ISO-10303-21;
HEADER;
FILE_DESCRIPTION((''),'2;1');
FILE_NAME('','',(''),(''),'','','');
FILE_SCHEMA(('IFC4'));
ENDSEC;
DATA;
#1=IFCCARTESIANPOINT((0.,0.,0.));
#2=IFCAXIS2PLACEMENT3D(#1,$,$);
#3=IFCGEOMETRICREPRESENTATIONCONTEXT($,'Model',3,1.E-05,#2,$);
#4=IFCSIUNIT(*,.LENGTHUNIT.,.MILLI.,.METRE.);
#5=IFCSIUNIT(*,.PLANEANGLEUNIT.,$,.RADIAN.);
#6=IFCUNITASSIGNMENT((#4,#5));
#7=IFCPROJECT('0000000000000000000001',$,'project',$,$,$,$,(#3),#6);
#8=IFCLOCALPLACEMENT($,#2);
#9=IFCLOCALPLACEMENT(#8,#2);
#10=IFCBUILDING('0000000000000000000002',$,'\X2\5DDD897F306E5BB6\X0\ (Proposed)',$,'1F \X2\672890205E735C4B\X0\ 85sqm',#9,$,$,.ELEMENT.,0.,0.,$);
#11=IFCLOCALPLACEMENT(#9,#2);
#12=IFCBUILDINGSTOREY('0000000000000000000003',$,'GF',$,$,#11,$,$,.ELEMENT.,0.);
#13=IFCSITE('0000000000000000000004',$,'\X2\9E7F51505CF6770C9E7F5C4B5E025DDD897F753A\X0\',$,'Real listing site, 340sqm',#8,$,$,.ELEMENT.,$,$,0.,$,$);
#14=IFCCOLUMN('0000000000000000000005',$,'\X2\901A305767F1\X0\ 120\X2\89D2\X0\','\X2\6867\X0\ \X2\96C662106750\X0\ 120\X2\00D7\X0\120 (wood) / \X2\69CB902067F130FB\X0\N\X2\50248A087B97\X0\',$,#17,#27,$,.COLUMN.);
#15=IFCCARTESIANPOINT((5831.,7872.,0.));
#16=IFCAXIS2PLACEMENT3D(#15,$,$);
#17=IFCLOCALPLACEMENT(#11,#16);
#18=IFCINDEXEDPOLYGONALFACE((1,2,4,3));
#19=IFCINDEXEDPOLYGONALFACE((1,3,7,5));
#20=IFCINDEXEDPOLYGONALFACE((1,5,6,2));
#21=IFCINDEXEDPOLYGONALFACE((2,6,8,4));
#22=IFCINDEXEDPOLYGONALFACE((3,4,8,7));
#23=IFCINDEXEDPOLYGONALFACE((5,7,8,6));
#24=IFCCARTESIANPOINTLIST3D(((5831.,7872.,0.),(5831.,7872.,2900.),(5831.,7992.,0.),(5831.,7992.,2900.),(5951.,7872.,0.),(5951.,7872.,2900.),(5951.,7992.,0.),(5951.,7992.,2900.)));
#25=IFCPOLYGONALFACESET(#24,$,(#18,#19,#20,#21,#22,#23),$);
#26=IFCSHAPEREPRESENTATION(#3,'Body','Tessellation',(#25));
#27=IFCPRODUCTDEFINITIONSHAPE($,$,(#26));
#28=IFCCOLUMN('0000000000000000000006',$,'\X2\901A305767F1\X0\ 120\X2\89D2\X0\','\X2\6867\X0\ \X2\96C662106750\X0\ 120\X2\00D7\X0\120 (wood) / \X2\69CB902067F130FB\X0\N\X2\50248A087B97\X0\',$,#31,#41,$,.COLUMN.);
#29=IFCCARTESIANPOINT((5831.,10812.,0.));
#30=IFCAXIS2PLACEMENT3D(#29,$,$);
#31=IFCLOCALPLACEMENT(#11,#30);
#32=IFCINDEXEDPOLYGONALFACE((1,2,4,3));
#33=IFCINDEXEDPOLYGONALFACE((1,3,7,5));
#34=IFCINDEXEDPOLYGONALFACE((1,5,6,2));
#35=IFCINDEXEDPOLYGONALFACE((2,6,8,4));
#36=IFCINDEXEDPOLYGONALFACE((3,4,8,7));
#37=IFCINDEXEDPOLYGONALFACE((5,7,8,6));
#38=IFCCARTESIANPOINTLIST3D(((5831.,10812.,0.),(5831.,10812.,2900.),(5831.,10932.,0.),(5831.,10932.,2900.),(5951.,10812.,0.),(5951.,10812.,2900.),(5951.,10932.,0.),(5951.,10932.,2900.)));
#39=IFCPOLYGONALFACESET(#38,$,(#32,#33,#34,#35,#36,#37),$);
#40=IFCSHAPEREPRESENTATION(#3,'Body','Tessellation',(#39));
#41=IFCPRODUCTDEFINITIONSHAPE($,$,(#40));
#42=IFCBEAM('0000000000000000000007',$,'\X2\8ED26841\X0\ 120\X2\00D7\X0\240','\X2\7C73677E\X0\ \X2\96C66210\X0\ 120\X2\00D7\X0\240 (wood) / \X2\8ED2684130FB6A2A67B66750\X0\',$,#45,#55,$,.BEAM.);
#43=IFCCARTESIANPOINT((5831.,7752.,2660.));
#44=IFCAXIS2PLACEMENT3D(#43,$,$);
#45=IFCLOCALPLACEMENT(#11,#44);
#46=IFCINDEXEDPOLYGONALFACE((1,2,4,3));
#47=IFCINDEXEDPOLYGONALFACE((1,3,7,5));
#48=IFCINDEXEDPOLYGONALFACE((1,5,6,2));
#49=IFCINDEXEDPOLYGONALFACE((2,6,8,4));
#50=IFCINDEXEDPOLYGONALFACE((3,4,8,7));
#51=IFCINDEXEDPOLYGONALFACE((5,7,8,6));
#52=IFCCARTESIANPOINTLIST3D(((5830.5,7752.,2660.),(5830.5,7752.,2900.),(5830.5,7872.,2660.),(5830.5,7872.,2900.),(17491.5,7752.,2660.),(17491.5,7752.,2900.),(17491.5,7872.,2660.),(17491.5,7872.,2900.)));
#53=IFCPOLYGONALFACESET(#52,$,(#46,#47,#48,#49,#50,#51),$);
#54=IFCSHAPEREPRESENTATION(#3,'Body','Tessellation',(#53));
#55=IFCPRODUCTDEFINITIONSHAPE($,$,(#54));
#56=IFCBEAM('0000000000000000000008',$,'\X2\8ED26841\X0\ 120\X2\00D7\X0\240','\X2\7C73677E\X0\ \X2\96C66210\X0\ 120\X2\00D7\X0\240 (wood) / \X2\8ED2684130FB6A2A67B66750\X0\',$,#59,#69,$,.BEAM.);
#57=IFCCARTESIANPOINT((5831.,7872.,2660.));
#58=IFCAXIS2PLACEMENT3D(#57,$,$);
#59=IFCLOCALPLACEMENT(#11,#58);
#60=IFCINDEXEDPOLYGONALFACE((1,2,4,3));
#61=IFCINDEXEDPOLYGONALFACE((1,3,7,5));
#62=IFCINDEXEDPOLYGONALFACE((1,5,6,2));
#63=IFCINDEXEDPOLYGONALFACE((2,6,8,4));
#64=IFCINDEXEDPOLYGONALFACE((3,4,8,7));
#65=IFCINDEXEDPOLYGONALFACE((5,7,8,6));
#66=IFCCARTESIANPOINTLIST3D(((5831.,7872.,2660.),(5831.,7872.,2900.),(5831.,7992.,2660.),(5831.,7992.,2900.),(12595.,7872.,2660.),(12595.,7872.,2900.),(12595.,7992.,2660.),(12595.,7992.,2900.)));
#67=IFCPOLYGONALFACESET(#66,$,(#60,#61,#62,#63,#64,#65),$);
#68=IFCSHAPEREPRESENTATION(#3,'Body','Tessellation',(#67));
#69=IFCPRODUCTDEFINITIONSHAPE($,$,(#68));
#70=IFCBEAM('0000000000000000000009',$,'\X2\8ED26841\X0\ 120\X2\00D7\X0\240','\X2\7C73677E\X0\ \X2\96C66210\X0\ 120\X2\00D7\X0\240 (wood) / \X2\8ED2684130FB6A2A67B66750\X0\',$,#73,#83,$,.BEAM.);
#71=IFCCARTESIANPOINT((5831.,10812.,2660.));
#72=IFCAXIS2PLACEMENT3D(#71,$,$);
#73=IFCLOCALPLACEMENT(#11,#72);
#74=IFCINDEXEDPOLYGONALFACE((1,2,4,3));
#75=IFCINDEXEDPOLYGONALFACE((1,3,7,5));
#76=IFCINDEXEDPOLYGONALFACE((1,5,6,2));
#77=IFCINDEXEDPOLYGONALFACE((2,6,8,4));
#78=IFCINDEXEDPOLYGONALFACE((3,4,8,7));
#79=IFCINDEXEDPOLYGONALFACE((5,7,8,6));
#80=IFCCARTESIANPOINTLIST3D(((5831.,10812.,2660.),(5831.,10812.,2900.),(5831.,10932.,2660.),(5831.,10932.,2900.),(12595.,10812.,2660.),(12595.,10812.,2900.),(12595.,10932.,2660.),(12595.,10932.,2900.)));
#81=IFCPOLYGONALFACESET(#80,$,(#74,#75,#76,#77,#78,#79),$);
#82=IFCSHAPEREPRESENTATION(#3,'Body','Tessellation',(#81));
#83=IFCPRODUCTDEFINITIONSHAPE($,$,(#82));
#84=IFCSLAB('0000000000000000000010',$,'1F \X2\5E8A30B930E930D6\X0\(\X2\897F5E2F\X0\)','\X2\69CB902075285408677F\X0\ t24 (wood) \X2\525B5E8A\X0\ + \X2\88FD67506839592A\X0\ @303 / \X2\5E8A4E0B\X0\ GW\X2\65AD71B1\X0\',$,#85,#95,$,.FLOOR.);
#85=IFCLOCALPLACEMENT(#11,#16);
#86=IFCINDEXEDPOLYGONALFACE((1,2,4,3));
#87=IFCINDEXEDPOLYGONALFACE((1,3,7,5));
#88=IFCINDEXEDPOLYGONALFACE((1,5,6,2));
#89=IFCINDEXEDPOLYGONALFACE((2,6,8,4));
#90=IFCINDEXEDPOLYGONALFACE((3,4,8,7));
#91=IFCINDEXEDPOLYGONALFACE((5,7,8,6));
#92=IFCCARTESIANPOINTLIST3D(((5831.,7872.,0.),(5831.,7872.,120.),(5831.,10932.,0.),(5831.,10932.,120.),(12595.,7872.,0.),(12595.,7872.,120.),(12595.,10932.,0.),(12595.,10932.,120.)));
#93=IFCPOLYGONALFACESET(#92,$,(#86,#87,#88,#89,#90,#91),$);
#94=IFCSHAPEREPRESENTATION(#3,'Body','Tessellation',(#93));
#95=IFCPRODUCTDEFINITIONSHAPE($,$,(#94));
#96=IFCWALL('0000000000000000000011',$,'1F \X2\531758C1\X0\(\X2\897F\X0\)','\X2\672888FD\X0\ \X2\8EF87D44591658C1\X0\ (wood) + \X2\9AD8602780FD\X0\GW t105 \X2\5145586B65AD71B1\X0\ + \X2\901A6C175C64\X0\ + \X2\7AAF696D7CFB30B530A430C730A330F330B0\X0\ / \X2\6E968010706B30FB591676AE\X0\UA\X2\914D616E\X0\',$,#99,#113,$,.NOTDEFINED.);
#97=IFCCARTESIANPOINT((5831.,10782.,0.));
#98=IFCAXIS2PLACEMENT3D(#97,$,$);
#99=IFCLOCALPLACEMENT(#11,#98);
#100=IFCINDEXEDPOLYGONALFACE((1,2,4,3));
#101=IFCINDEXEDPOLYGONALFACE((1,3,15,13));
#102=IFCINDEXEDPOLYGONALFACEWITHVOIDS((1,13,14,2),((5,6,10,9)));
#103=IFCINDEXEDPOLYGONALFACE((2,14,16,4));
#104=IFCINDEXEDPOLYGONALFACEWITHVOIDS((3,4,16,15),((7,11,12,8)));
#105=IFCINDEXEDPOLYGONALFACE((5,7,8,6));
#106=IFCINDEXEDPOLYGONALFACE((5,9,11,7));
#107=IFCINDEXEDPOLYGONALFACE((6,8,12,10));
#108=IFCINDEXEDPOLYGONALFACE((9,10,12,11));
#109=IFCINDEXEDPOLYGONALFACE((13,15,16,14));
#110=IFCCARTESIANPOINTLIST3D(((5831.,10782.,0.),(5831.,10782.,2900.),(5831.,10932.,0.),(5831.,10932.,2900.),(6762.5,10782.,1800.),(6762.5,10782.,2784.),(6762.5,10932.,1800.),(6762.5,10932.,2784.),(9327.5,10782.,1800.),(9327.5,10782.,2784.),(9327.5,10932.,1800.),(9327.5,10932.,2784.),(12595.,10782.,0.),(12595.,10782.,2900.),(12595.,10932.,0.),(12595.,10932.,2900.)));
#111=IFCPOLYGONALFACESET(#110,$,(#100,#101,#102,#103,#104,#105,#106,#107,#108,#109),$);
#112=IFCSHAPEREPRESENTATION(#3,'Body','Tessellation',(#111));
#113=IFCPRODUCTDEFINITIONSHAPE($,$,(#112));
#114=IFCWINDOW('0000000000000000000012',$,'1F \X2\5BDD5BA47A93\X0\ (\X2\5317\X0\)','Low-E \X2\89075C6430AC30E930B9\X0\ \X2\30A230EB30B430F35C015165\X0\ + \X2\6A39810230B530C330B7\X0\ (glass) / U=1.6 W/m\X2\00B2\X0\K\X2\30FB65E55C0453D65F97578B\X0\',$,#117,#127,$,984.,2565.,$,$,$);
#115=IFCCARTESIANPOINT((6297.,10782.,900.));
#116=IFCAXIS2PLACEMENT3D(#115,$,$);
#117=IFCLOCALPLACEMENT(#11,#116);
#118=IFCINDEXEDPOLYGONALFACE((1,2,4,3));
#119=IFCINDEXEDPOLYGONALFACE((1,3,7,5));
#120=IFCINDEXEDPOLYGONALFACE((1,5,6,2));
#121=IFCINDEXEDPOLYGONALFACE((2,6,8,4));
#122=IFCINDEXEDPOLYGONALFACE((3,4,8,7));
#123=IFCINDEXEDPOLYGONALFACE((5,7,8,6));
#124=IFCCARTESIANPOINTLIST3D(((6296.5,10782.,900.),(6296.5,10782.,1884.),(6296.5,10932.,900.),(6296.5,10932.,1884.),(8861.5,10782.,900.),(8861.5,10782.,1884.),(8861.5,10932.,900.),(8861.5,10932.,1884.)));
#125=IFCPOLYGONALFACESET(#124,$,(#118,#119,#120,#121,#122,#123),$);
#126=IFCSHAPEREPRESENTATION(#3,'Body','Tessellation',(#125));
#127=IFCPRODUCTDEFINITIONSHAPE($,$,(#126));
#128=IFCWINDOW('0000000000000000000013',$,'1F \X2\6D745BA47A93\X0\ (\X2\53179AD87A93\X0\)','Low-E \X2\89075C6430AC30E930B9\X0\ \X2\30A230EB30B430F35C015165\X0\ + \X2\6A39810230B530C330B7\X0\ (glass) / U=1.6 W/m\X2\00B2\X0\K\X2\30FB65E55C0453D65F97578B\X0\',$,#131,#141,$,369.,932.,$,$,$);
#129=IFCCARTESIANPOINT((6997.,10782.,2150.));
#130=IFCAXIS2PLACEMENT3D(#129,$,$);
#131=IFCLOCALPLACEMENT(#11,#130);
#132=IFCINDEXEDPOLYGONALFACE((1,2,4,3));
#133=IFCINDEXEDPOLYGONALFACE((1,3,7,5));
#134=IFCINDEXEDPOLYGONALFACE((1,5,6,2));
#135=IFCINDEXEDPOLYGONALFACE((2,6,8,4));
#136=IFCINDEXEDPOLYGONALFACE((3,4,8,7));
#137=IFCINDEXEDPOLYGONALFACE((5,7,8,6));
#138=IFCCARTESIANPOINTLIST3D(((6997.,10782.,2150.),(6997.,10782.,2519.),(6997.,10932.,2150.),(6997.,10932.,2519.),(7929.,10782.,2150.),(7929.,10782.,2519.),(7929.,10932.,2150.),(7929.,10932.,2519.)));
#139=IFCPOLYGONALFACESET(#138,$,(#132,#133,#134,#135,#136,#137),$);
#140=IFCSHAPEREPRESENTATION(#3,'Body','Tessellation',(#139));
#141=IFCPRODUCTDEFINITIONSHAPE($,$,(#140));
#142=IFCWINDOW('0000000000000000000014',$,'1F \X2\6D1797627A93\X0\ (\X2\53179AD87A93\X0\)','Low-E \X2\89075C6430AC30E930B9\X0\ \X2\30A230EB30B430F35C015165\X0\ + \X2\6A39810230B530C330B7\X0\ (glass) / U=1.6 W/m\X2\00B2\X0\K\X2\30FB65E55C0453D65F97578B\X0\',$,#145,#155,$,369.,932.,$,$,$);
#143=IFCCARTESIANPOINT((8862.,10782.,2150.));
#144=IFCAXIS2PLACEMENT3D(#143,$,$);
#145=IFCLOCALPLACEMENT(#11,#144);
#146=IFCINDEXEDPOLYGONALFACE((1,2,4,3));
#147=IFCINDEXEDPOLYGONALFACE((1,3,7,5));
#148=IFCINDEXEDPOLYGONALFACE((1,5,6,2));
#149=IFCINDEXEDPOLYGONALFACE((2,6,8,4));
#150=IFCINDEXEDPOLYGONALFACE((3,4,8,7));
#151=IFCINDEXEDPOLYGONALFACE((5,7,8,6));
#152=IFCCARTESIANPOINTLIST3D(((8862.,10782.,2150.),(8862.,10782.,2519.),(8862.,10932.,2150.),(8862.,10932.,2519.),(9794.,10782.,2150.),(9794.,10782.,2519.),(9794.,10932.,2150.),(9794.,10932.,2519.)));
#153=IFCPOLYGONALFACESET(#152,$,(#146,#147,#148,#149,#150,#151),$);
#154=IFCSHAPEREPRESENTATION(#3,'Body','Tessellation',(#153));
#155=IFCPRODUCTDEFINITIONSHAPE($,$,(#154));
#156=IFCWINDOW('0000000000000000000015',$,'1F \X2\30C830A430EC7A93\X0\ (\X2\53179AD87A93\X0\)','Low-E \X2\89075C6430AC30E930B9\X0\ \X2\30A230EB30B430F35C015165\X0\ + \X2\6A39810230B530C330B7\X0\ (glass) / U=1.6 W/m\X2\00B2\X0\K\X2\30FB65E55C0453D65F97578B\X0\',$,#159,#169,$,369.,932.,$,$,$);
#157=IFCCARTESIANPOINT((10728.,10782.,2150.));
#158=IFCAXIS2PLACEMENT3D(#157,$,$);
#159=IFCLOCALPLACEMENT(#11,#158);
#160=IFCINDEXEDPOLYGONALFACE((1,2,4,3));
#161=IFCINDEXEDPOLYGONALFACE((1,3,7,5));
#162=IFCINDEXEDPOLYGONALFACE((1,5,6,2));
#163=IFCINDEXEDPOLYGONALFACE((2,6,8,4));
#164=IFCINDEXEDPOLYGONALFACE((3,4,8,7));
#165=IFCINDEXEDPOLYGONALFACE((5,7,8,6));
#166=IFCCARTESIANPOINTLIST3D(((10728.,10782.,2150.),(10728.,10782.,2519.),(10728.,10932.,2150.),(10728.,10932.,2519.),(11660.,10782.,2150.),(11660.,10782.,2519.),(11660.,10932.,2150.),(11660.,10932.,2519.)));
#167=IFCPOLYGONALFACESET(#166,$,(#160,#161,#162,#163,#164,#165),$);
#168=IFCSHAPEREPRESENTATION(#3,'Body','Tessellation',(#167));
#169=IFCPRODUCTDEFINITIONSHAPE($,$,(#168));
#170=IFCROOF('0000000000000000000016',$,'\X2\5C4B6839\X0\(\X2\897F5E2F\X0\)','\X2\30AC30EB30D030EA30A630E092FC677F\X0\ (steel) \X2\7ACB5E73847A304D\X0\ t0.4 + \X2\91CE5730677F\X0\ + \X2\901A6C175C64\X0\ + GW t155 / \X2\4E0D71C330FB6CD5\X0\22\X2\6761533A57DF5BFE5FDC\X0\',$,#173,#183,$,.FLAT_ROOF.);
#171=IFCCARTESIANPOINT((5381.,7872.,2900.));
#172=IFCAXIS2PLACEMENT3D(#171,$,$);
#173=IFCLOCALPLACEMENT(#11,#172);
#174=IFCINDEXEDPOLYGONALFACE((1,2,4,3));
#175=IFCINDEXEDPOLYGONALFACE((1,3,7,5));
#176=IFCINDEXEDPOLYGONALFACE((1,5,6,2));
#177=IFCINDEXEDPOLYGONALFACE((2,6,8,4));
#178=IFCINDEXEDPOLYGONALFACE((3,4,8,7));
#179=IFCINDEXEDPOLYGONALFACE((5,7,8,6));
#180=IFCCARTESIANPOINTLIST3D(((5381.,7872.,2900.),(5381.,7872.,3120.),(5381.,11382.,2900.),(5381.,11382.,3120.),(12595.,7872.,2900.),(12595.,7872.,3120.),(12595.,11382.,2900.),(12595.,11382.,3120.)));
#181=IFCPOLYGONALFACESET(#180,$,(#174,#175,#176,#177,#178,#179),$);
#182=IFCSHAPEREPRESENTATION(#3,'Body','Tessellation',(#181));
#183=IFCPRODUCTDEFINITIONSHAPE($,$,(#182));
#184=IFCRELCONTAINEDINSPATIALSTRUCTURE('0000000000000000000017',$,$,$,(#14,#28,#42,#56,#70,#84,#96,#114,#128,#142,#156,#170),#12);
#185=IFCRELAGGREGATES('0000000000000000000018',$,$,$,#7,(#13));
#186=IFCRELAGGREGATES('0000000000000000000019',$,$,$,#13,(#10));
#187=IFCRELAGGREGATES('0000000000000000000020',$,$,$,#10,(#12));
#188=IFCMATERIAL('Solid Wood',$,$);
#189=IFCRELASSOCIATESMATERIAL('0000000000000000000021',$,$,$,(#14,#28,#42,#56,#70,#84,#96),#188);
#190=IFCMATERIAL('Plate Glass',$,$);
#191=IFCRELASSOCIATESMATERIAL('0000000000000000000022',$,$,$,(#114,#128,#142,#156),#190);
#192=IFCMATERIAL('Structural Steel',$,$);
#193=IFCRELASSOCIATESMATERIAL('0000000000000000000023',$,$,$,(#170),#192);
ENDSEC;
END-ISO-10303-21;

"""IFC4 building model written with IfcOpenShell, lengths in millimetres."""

from ifc_helpers import new_model, si_unit, frame, frame_2d, origin, place, context, project, spatial, rectangle, extrude, material, element, fill, save


model = new_model("IFC4")

# Units and contexts
model_context = context("Model", 3, precision=1e-05, world=origin())
ifc_project = project(units=[si_unit("LENGTHUNIT", "METRE", prefix="MILLI"), si_unit("PLANEANGLEUNIT", "RADIAN")], contexts=[model_context])

# Site, building, storey
site_placement = place(None, origin())
site = spatial("IfcSite", under=ifc_project, at=site_placement, Name="鹿児島県鹿屋市川西町", ObjectType="Real listing site, 340sqm", CompositionType="ELEMENT", RefElevation=0.0)
building_placement = place(site_placement, origin())
building = spatial("IfcBuilding", under=site, at=building_placement, Name="川西の家 (Proposed)", ObjectType="1F 木造平屋 85sqm", CompositionType="ELEMENT", ElevationOfRefHeight=0.0, ElevationOfTerrain=0.0)
storey_placement = place(building_placement, origin())
storey = spatial("IfcBuildingStorey", under=building, at=storey_placement, Name="GF", CompositionType="ELEMENT", Elevation=0.0)

# Columns
ifc_material_1 = material(Name="Solid Wood")
column_1_placement = place(storey_placement, frame((5831.0, 7872.0, 0.0)))
element("IfcColumn", 1, at=column_1_placement, inside=storey, material=ifc_material_1, Name="通し柱 120角", Description="桧 集成材 120×120 (wood) / 構造柱・N値計算", PredefinedType="COLUMN", context=model_context, shape_type="SweptSolid", body=[
    extrude(rectangle(XDim=120.0, YDim=120.0, at=frame_2d((60.0, 60.0))), frame((5831.0, 7872.0, 0.0)), (0.0, 0.0, 1.0), 2900.0),
])
column_2_placement = place(storey_placement, frame((5831.0, 10812.0, 0.0)))
element("IfcColumn", 2, at=column_2_placement, inside=storey, material=ifc_material_1, Name="通し柱 120角", Description="桧 集成材 120×120 (wood) / 構造柱・N値計算", PredefinedType="COLUMN", context=model_context, shape_type="SweptSolid", body=[
    extrude(rectangle(XDim=120.0, YDim=120.0, at=frame_2d((60.0, 60.0))), frame((5831.0, 10812.0, 0.0)), (0.0, 0.0, 1.0), 2900.0),
])

# Beams
beam_1_placement = place(storey_placement, frame((5831.0, 7752.0, 2660.0)))
element("IfcBeam", 3, at=beam_1_placement, inside=storey, material=ifc_material_1, Name="軒桁 120×240", Description="米松 集成 120×240 (wood) / 軒桁・横架材", PredefinedType="BEAM", context=model_context, shape_type="SweptSolid", body=[
    extrude(rectangle(XDim=11661.0, YDim=120.0, at=frame_2d((5830.0, 60.0))), frame((5831.0, 7752.0, 2660.0)), (0.0, 0.0, 1.0), 240.0),
])
beam_2_placement = place(storey_placement, frame((5831.0, 7872.0, 2660.0)))
element("IfcBeam", 4, at=beam_2_placement, inside=storey, material=ifc_material_1, Name="軒桁 120×240", Description="米松 集成 120×240 (wood) / 軒桁・横架材", PredefinedType="BEAM", context=model_context, shape_type="SweptSolid", body=[
    extrude(rectangle(XDim=6764.0, YDim=120.0, at=frame_2d((3382.0, 60.0))), frame((5831.0, 7872.0, 2660.0)), (0.0, 0.0, 1.0), 240.0),
])
beam_3_placement = place(storey_placement, frame((5831.0, 10812.0, 2660.0)))
element("IfcBeam", 5, at=beam_3_placement, inside=storey, material=ifc_material_1, Name="軒桁 120×240", Description="米松 集成 120×240 (wood) / 軒桁・横架材", PredefinedType="BEAM", context=model_context, shape_type="SweptSolid", body=[
    extrude(rectangle(XDim=6764.0, YDim=120.0, at=frame_2d((3382.0, 60.0))), frame((5831.0, 10812.0, 2660.0)), (0.0, 0.0, 1.0), 240.0),
])

# Slab
slab_placement = place(storey_placement, frame((5831.0, 7872.0, 0.0)))
element("IfcSlab", 6, at=slab_placement, inside=storey, material=ifc_material_1, Name="1F 床スラブ(西帯)", Description="構造用合板 t24 (wood) 剛床 + 製材根太 @303 / 床下 GW断熱", PredefinedType="FLOOR", context=model_context, shape_type="SweptSolid", body=[
    extrude(rectangle(XDim=6764.0, YDim=3060.0, at=frame_2d((3382.0, 1530.0))), frame((5831.0, 7872.0, 0.0)), (0.0, 0.0, 1.0), 120.0),
])

# Wall, openings, windows
wall_1_placement = place(storey_placement, frame((5831.0, 10782.0, 0.0)))
wall_1 = element("IfcWall", 7, at=wall_1_placement, inside=storey, material=ifc_material_1, Name="1F 北壁(西)", Description="木製 軸組外壁 (wood) + 高性能GW t105 充填断熱 + 通気層 + 窯業系サイディング / 準耐火・外皮UA配慮", PredefinedType="NOTDEFINED", context=model_context, shape_type="SweptSolid", body=[
    extrude(rectangle(XDim=6764.0, YDim=150.0, at=frame_2d((3382.0, 75.0))), frame((5831.0, 10782.0, 0.0)), (0.0, 0.0, 1.0), 2900.0),
])
opening_1_placement = place(storey_placement, frame((6297.0, 10782.0, 900.0)))
opening_1 = element("IfcOpeningElement", 8, at=opening_1_placement, cuts=wall_1, PredefinedType="NOTDEFINED", context=model_context, shape_type="SweptSolid", body=[
    extrude(rectangle(XDim=2565.0, YDim=150.0, at=frame_2d((1282.0, 75.0))), frame((6297.0, 10782.0, 900.0)), (0.0, 0.0, 1.0), 984.0),
])
opening_2_placement = place(storey_placement, frame((6997.0, 10782.0, 2150.0)))
opening_2 = element("IfcOpeningElement", 9, at=opening_2_placement, cuts=wall_1, PredefinedType="NOTDEFINED", context=model_context, shape_type="SweptSolid", body=[
    extrude(rectangle(XDim=932.0, YDim=150.0, at=frame_2d((466.0, 75.0))), frame((6997.0, 10782.0, 2150.0)), (0.0, 0.0, 1.0), 369.0),
])
opening_3_placement = place(storey_placement, frame((8862.0, 10782.0, 2150.0)))
opening_3 = element("IfcOpeningElement", 10, at=opening_3_placement, cuts=wall_1, PredefinedType="NOTDEFINED", context=model_context, shape_type="SweptSolid", body=[
    extrude(rectangle(XDim=932.0, YDim=150.0, at=frame_2d((466.0, 75.0))), frame((8862.0, 10782.0, 2150.0)), (0.0, 0.0, 1.0), 369.0),
])
opening_4_placement = place(storey_placement, frame((10728.0, 10782.0, 2150.0)))
opening_4 = element("IfcOpeningElement", 11, at=opening_4_placement, cuts=wall_1, PredefinedType="NOTDEFINED", context=model_context, shape_type="SweptSolid", body=[
    extrude(rectangle(XDim=932.0, YDim=150.0, at=frame_2d((466.0, 75.0))), frame((10728.0, 10782.0, 2150.0)), (0.0, 0.0, 1.0), 369.0),
])
ifc_material_2 = material(Name="Plate Glass")
window_1_placement = place(storey_placement, frame((6297.0, 10782.0, 900.0)))
window_1 = element("IfcWindow", 12, at=window_1_placement, inside=storey, material=ifc_material_2, Name="1F 寝室窓 (北)", Description="Low-E 複層ガラス アルゴン封入 + 樹脂サッシ (glass) / U=1.6 W/m²K・日射取得型", OverallHeight=984.0, OverallWidth=2565.0, context=model_context, shape_type="SweptSolid", body=[
    extrude(rectangle(XDim=2565.0, YDim=150.0, at=frame_2d((1282.0, 75.0))), frame((6297.0, 10782.0, 900.0)), (0.0, 0.0, 1.0), 984.0),
])
fill(opening_1, window_1)
window_2_placement = place(storey_placement, frame((6997.0, 10782.0, 2150.0)))
window_2 = element("IfcWindow", 13, at=window_2_placement, inside=storey, material=ifc_material_2, Name="1F 浴室窓 (北高窓)", Description="Low-E 複層ガラス アルゴン封入 + 樹脂サッシ (glass) / U=1.6 W/m²K・日射取得型", OverallHeight=369.0, OverallWidth=932.0, context=model_context, shape_type="SweptSolid", body=[
    extrude(rectangle(XDim=932.0, YDim=150.0, at=frame_2d((466.0, 75.0))), frame((6997.0, 10782.0, 2150.0)), (0.0, 0.0, 1.0), 369.0),
])
fill(opening_2, window_2)
window_3_placement = place(storey_placement, frame((8862.0, 10782.0, 2150.0)))
window_3 = element("IfcWindow", 14, at=window_3_placement, inside=storey, material=ifc_material_2, Name="1F 洗面窓 (北高窓)", Description="Low-E 複層ガラス アルゴン封入 + 樹脂サッシ (glass) / U=1.6 W/m²K・日射取得型", OverallHeight=369.0, OverallWidth=932.0, context=model_context, shape_type="SweptSolid", body=[
    extrude(rectangle(XDim=932.0, YDim=150.0, at=frame_2d((466.0, 75.0))), frame((8862.0, 10782.0, 2150.0)), (0.0, 0.0, 1.0), 369.0),
])
fill(opening_3, window_3)
window_4_placement = place(storey_placement, frame((10728.0, 10782.0, 2150.0)))
window_4 = element("IfcWindow", 15, at=window_4_placement, inside=storey, material=ifc_material_2, Name="1F トイレ窓 (北高窓)", Description="Low-E 複層ガラス アルゴン封入 + 樹脂サッシ (glass) / U=1.6 W/m²K・日射取得型", OverallHeight=369.0, OverallWidth=932.0, context=model_context, shape_type="SweptSolid", body=[
    extrude(rectangle(XDim=932.0, YDim=150.0, at=frame_2d((466.0, 75.0))), frame((10728.0, 10782.0, 2150.0)), (0.0, 0.0, 1.0), 369.0),
])
fill(opening_4, window_4)

# Roof
ifc_material_3 = material(Name="Structural Steel")
roof_placement = place(storey_placement, frame((5381.0, 7872.0, 2900.0)))
element("IfcRoof", 16, at=roof_placement, inside=storey, material=ifc_material_3, Name="屋根(西帯)", Description="ガルバリウム鋼板 (steel) 立平葺き t0.4 + 野地板 + 通気層 + GW t155 / 不燃・法22条区域対応", PredefinedType="FLAT_ROOF", context=model_context, shape_type="SweptSolid", body=[
    extrude(rectangle(XDim=7214.0, YDim=3510.0, at=frame_2d((3607.0, 1755.0))), frame((5381.0, 7872.0, 2900.0)), (0.0, 0.0, 1.0), 220.0),
])

save(model, "model.ifc")
